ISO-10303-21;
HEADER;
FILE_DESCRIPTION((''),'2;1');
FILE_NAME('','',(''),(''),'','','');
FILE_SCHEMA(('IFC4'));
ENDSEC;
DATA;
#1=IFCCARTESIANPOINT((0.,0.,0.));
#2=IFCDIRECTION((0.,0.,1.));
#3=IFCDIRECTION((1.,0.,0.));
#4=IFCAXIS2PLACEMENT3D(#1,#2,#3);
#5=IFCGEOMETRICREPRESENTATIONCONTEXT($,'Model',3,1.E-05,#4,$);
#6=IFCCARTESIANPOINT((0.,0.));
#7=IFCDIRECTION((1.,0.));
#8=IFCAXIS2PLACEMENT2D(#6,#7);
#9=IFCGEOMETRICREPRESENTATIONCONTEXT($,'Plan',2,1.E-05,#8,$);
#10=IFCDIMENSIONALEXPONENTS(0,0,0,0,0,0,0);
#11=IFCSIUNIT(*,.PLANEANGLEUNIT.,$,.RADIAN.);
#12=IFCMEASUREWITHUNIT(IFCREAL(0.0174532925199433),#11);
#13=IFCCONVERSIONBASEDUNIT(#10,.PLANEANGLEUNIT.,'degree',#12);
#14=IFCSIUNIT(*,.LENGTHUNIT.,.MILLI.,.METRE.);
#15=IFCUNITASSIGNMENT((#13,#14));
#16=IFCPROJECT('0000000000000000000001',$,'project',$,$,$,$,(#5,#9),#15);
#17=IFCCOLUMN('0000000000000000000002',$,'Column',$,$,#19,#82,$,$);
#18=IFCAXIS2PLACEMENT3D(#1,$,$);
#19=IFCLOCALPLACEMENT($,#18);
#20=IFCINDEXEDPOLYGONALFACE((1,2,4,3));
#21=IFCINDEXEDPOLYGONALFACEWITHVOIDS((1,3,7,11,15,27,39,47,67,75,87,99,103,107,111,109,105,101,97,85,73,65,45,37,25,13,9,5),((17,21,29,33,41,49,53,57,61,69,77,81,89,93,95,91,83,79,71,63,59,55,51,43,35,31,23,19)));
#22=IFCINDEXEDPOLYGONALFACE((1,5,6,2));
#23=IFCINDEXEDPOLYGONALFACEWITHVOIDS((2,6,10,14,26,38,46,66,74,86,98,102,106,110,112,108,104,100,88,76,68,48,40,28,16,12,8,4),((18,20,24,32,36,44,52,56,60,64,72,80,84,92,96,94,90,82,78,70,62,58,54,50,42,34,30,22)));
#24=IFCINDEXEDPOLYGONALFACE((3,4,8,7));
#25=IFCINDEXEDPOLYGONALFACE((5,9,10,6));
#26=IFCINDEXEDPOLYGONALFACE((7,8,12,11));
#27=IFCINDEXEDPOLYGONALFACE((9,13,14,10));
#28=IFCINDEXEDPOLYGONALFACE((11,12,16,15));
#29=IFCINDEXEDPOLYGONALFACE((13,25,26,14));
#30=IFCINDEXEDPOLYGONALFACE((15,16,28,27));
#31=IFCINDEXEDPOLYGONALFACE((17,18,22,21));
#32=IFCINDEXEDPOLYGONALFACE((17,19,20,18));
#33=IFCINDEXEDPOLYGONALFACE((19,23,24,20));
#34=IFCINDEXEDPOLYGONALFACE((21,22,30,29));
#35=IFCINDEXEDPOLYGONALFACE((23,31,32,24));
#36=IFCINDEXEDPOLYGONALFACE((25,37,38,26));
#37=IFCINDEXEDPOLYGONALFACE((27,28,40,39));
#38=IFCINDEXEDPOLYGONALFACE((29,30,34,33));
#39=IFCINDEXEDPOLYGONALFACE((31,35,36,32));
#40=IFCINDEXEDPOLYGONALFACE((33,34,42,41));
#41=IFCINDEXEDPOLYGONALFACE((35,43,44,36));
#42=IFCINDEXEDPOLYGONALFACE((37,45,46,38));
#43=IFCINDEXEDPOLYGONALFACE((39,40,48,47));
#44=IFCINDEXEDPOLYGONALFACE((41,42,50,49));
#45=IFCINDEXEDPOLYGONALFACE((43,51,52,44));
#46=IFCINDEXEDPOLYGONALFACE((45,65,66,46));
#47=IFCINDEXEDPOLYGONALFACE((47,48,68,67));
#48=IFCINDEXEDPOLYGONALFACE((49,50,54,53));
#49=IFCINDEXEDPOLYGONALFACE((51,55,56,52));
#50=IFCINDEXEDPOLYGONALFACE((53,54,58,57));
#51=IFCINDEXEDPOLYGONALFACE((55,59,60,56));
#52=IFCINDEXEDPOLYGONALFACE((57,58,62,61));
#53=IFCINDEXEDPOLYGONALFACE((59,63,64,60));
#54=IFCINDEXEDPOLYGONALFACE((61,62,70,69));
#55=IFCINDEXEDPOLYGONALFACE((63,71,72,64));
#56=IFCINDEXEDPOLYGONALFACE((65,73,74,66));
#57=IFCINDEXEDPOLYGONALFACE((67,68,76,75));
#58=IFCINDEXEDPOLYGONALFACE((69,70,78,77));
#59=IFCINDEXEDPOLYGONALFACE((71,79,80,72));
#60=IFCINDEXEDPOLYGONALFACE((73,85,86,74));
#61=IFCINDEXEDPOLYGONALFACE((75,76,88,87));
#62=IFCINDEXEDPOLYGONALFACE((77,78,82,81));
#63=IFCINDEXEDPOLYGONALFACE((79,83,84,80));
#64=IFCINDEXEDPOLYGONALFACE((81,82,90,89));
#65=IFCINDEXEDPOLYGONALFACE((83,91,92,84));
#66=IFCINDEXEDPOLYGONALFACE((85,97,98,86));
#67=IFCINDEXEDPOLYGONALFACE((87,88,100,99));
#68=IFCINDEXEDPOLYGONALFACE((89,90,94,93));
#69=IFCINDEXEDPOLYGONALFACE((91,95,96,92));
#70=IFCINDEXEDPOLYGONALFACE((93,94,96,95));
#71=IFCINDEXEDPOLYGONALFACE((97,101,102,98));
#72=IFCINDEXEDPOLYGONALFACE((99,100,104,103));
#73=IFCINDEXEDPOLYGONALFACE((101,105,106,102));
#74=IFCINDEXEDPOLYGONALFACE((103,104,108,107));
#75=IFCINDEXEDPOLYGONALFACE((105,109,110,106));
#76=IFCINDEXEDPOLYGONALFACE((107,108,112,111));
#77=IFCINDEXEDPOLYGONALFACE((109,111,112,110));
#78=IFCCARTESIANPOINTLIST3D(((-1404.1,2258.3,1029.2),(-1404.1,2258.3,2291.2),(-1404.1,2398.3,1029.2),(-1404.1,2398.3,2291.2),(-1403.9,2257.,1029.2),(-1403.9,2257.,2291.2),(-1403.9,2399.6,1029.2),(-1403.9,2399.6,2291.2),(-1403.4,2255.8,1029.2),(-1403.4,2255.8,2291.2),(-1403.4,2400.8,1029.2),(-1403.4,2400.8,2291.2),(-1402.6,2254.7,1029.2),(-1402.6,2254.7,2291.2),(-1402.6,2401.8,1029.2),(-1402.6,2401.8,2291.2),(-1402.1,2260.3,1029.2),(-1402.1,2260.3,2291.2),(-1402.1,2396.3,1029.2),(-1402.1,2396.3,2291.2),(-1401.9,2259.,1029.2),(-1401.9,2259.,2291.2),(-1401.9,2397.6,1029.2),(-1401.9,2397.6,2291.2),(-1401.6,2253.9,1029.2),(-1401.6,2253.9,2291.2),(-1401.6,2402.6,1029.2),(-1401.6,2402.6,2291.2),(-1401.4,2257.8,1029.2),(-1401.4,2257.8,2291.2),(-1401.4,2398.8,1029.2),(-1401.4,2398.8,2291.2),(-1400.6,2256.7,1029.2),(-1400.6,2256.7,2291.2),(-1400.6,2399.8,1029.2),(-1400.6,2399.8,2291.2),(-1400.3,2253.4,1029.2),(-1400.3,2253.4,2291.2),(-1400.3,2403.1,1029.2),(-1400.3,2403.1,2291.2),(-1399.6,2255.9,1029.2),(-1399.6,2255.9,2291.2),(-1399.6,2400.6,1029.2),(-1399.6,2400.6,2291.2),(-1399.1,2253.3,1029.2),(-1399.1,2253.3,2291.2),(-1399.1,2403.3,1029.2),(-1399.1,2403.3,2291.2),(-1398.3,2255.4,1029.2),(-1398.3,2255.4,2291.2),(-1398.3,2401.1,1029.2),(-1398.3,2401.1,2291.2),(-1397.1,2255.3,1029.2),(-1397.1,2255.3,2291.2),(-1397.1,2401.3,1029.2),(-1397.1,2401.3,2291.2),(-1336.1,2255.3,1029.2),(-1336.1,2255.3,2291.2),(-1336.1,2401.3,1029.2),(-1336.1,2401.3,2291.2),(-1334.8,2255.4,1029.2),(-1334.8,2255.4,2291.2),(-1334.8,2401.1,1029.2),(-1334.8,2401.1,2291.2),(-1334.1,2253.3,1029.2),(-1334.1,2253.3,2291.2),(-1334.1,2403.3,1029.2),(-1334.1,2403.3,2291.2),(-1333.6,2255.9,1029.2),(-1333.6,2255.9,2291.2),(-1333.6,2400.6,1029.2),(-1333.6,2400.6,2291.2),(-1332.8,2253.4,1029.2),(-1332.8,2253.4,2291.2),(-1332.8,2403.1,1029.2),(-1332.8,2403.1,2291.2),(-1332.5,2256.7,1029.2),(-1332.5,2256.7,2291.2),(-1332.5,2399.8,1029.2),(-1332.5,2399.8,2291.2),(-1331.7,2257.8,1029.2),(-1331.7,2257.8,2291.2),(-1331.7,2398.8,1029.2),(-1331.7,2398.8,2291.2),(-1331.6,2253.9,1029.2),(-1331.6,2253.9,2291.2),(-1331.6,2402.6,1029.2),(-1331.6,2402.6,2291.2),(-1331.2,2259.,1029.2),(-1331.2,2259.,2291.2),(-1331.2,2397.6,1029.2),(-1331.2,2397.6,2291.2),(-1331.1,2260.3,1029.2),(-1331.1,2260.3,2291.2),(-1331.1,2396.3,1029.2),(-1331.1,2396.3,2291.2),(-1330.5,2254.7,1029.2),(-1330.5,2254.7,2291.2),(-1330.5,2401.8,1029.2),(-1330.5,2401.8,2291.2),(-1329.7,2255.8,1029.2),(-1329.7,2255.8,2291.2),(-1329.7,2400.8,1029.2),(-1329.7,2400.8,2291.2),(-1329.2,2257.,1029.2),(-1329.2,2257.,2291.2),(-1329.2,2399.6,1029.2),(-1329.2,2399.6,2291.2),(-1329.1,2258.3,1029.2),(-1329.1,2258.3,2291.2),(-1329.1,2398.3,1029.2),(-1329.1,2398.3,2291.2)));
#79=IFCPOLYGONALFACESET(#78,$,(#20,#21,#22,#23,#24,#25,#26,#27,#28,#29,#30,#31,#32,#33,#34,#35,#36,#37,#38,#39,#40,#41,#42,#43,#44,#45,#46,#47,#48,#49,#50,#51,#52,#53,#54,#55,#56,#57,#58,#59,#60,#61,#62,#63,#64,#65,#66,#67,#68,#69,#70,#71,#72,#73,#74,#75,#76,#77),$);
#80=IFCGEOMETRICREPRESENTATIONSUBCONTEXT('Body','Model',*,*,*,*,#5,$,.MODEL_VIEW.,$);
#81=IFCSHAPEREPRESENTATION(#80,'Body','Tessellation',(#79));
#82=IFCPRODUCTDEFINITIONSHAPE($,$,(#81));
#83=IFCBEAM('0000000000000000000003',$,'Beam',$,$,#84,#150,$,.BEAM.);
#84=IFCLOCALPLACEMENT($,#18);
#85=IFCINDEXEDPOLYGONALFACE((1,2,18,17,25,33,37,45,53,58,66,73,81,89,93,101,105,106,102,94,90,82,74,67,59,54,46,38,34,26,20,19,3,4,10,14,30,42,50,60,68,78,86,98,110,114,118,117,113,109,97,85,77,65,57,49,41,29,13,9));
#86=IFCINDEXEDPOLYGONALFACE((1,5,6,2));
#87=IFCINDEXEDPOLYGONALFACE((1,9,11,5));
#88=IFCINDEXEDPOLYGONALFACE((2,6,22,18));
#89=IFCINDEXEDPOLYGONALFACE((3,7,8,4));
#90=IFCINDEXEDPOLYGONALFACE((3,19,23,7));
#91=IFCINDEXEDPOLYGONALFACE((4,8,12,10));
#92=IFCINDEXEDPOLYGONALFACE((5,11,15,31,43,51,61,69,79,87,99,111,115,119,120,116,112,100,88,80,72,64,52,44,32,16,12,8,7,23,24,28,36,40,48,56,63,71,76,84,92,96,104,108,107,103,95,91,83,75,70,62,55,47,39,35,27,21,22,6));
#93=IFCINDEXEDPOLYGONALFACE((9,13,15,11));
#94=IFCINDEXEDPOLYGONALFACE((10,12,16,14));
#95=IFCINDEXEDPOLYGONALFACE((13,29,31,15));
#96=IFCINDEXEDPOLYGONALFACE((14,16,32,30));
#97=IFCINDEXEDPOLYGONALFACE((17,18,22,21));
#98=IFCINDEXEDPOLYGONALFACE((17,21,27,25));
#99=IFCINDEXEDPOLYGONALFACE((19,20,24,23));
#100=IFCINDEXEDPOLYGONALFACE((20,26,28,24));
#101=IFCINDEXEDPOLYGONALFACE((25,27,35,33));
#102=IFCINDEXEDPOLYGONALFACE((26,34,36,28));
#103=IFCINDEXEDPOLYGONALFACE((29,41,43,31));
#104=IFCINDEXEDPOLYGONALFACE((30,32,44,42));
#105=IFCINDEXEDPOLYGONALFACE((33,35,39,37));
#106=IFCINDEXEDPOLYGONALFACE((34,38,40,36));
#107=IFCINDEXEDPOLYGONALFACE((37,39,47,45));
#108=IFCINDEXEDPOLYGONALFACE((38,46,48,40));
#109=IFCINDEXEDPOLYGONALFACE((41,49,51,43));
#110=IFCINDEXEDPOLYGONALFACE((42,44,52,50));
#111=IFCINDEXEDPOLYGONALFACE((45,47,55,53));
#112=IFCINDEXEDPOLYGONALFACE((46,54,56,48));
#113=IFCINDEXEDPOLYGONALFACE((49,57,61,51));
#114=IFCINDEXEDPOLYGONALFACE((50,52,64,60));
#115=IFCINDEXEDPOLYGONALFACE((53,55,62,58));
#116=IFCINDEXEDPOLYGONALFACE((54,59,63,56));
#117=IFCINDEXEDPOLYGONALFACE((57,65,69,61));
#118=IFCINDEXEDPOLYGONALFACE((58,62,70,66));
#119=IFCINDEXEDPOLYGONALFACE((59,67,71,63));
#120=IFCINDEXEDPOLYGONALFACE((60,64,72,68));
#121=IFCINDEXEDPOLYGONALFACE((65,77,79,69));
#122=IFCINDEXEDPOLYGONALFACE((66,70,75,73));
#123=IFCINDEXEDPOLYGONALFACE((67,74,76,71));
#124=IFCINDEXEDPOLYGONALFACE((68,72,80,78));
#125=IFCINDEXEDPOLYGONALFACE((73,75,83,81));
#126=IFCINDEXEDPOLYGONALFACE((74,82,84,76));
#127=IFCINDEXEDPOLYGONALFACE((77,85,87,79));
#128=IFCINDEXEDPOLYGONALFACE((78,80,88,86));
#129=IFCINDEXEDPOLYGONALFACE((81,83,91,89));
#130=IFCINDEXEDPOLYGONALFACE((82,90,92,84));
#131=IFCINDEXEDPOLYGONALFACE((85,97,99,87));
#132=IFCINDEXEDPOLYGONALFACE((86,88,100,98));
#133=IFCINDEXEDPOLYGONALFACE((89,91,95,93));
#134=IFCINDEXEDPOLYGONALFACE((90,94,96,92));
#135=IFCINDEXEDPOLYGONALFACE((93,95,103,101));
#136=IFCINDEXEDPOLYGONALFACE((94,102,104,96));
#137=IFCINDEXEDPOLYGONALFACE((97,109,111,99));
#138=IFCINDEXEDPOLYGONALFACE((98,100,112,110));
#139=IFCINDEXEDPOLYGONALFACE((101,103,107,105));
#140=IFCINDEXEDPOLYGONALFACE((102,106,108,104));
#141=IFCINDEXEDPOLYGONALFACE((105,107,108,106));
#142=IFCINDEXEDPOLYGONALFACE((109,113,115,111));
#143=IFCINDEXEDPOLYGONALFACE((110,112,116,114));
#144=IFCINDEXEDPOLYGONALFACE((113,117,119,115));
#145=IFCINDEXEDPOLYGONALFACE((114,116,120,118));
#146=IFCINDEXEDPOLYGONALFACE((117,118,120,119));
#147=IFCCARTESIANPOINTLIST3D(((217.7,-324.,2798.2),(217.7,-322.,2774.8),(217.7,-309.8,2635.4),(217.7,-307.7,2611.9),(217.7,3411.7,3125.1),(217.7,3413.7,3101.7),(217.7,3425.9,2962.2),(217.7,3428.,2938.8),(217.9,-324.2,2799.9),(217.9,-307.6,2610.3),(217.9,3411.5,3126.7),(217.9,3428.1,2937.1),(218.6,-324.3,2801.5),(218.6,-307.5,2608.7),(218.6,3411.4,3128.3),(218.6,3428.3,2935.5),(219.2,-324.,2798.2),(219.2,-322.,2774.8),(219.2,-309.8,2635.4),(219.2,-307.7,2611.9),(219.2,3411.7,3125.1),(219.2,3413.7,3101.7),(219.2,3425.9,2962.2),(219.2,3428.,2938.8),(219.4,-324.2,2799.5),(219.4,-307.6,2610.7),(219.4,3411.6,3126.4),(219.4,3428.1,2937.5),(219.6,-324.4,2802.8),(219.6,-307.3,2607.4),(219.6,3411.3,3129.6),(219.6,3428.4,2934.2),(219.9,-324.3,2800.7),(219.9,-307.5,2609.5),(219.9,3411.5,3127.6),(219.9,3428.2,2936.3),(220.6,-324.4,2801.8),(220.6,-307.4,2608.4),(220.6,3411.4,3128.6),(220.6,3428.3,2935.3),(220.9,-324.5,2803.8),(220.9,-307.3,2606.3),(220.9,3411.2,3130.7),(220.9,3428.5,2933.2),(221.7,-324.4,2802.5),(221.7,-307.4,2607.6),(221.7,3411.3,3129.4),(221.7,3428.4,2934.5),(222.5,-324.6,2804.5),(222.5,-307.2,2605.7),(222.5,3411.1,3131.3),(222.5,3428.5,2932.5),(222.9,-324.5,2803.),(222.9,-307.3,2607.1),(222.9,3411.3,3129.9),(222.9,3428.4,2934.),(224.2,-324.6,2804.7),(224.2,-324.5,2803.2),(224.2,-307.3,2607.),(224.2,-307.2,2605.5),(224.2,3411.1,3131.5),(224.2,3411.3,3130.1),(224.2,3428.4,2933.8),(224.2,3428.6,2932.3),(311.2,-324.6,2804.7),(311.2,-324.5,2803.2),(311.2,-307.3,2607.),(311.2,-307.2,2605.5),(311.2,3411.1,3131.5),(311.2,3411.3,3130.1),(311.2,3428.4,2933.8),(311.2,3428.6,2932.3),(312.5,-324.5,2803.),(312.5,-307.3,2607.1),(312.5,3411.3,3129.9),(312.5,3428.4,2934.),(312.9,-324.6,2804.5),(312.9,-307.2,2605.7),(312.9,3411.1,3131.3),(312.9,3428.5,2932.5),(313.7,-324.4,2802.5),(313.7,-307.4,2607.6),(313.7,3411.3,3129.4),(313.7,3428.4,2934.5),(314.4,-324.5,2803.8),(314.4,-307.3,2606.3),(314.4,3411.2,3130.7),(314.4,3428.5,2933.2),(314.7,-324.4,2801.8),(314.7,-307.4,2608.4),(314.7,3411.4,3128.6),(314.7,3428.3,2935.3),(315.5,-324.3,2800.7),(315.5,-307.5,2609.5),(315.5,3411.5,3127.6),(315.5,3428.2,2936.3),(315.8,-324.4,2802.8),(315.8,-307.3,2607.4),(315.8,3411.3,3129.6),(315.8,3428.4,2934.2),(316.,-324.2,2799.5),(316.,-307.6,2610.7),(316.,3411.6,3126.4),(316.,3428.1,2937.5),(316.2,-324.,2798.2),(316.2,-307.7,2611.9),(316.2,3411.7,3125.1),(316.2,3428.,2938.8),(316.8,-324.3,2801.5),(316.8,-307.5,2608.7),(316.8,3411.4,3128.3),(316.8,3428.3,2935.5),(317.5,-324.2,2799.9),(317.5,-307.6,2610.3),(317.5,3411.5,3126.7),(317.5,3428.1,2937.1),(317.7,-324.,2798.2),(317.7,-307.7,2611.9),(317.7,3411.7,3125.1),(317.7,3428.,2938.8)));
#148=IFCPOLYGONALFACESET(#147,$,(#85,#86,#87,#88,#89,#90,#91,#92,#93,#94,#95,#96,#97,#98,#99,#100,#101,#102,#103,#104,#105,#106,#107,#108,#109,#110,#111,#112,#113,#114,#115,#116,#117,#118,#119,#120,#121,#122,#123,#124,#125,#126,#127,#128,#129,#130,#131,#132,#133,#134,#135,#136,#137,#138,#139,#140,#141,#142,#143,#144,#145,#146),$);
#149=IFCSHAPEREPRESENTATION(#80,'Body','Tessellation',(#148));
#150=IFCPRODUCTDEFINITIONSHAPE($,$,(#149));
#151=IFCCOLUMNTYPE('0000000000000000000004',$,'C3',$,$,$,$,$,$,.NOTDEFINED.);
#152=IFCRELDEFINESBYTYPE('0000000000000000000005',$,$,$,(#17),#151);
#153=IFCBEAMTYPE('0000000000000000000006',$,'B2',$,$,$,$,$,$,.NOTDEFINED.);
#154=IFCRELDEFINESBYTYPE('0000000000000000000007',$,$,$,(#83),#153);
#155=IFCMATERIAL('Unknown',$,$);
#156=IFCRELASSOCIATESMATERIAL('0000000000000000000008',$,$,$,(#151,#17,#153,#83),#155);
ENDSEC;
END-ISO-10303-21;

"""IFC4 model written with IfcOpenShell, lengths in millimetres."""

from ifc_helpers import new_model, entity, si_unit, converted_unit, frame, origin_with_axes, origin_2d_with_axis, place, context, subcontext, project, hollow_rectangle, c_section, extrude, material, material_profile, profile_set, profile_usage, type_object, element, save


model = new_model("IFC4")

# Units and contexts
model_context = context("Model", 3, precision=1e-05, world=origin_with_axes())
plan_context = context("Plan", 2, precision=1e-05, world=origin_2d_with_axis())
body_context = subcontext(model_context, "Body", "Model", "MODEL_VIEW")
ifc_project = project(units=[converted_unit("PLANEANGLEUNIT", "degree", entity("IfcReal", 0.0174532925199433), si_unit("PLANEANGLEUNIT", "RADIAN"), dimensions=[0, 0, 0, 0, 0, 0, 0]), si_unit("LENGTHUNIT", "METRE", prefix="MILLI")], contexts=[model_context, plan_context])

# Column
ifc_material = material(Name="Unknown")
ifc_material_profile_1 = material_profile(ifc_material, hollow_rectangle(XDim=75.0, YDim=150.0, WallThickness=2.0, InnerFilletRadius=5.0, OuterFilletRadius=5.0))
ifc_profile_set_1 = profile_set([ifc_material_profile_1])
ifc_profile_usage_1 = profile_usage(ifc_profile_set_1, cardinal=5)
column_type = type_object("IfcColumnType", Name="C3", PredefinedType="NOTDEFINED", material=ifc_profile_set_1)
placement = place(None, frame((0.0, 0.0, -150.0), z_axis=(0.0, 0.0, 1.0), x_axis=(1.0, 0.0, 0.0)))
column_placement = place(placement, frame((-1366.6, 2328.3, 1179.2), z_axis=(0.0, 0.0, 1.0), x_axis=(1.0, 0.0, 0.0)))
element("IfcColumn", 1, at=column_placement, type_object=column_type, material=ifc_profile_usage_1, Name="Column", context=body_context, shape_type="SweptSolid", body=[
    extrude(hollow_rectangle(XDim=75.0, YDim=150.0, WallThickness=2.0, InnerFilletRadius=5.0, OuterFilletRadius=5.0), origin_with_axes(), (0.0, 0.0, 1.0), 1262.0),
])

# Beam
ifc_material_profile_2 = material_profile(ifc_material, c_section(Depth=200.0, Width=100.0, WallThickness=1.5, Girth=30.0, InternalFilletRadius=5.0))
ifc_profile_set_2 = profile_set([ifc_material_profile_2])
ifc_profile_usage_2 = profile_usage(ifc_profile_set_2, cardinal=5)
beam_type_1 = type_object("IfcBeamType", Name="B2", PredefinedType="NOTDEFINED", material=ifc_profile_set_2)
beam_1_placement = place(None, frame((267.7, -315.9, 2705.1), z_axis=(0.0, 0.996195, 0.087156), x_axis=(-1.0, 0.0, 0.0)))
element("IfcBeam", 2, at=beam_1_placement, type_object=beam_type_1, material=ifc_profile_usage_2, Name="Beam", PredefinedType="BEAM", context=body_context, shape_type="SweptSolid", body=[
    extrude(c_section(Depth=200.0, Width=100.0, WallThickness=1.5, Girth=30.0, InternalFilletRadius=5.0), origin_with_axes(), (0.0, 0.0, 1.0), 3750.0),
])

save(model, "model.ifc")
